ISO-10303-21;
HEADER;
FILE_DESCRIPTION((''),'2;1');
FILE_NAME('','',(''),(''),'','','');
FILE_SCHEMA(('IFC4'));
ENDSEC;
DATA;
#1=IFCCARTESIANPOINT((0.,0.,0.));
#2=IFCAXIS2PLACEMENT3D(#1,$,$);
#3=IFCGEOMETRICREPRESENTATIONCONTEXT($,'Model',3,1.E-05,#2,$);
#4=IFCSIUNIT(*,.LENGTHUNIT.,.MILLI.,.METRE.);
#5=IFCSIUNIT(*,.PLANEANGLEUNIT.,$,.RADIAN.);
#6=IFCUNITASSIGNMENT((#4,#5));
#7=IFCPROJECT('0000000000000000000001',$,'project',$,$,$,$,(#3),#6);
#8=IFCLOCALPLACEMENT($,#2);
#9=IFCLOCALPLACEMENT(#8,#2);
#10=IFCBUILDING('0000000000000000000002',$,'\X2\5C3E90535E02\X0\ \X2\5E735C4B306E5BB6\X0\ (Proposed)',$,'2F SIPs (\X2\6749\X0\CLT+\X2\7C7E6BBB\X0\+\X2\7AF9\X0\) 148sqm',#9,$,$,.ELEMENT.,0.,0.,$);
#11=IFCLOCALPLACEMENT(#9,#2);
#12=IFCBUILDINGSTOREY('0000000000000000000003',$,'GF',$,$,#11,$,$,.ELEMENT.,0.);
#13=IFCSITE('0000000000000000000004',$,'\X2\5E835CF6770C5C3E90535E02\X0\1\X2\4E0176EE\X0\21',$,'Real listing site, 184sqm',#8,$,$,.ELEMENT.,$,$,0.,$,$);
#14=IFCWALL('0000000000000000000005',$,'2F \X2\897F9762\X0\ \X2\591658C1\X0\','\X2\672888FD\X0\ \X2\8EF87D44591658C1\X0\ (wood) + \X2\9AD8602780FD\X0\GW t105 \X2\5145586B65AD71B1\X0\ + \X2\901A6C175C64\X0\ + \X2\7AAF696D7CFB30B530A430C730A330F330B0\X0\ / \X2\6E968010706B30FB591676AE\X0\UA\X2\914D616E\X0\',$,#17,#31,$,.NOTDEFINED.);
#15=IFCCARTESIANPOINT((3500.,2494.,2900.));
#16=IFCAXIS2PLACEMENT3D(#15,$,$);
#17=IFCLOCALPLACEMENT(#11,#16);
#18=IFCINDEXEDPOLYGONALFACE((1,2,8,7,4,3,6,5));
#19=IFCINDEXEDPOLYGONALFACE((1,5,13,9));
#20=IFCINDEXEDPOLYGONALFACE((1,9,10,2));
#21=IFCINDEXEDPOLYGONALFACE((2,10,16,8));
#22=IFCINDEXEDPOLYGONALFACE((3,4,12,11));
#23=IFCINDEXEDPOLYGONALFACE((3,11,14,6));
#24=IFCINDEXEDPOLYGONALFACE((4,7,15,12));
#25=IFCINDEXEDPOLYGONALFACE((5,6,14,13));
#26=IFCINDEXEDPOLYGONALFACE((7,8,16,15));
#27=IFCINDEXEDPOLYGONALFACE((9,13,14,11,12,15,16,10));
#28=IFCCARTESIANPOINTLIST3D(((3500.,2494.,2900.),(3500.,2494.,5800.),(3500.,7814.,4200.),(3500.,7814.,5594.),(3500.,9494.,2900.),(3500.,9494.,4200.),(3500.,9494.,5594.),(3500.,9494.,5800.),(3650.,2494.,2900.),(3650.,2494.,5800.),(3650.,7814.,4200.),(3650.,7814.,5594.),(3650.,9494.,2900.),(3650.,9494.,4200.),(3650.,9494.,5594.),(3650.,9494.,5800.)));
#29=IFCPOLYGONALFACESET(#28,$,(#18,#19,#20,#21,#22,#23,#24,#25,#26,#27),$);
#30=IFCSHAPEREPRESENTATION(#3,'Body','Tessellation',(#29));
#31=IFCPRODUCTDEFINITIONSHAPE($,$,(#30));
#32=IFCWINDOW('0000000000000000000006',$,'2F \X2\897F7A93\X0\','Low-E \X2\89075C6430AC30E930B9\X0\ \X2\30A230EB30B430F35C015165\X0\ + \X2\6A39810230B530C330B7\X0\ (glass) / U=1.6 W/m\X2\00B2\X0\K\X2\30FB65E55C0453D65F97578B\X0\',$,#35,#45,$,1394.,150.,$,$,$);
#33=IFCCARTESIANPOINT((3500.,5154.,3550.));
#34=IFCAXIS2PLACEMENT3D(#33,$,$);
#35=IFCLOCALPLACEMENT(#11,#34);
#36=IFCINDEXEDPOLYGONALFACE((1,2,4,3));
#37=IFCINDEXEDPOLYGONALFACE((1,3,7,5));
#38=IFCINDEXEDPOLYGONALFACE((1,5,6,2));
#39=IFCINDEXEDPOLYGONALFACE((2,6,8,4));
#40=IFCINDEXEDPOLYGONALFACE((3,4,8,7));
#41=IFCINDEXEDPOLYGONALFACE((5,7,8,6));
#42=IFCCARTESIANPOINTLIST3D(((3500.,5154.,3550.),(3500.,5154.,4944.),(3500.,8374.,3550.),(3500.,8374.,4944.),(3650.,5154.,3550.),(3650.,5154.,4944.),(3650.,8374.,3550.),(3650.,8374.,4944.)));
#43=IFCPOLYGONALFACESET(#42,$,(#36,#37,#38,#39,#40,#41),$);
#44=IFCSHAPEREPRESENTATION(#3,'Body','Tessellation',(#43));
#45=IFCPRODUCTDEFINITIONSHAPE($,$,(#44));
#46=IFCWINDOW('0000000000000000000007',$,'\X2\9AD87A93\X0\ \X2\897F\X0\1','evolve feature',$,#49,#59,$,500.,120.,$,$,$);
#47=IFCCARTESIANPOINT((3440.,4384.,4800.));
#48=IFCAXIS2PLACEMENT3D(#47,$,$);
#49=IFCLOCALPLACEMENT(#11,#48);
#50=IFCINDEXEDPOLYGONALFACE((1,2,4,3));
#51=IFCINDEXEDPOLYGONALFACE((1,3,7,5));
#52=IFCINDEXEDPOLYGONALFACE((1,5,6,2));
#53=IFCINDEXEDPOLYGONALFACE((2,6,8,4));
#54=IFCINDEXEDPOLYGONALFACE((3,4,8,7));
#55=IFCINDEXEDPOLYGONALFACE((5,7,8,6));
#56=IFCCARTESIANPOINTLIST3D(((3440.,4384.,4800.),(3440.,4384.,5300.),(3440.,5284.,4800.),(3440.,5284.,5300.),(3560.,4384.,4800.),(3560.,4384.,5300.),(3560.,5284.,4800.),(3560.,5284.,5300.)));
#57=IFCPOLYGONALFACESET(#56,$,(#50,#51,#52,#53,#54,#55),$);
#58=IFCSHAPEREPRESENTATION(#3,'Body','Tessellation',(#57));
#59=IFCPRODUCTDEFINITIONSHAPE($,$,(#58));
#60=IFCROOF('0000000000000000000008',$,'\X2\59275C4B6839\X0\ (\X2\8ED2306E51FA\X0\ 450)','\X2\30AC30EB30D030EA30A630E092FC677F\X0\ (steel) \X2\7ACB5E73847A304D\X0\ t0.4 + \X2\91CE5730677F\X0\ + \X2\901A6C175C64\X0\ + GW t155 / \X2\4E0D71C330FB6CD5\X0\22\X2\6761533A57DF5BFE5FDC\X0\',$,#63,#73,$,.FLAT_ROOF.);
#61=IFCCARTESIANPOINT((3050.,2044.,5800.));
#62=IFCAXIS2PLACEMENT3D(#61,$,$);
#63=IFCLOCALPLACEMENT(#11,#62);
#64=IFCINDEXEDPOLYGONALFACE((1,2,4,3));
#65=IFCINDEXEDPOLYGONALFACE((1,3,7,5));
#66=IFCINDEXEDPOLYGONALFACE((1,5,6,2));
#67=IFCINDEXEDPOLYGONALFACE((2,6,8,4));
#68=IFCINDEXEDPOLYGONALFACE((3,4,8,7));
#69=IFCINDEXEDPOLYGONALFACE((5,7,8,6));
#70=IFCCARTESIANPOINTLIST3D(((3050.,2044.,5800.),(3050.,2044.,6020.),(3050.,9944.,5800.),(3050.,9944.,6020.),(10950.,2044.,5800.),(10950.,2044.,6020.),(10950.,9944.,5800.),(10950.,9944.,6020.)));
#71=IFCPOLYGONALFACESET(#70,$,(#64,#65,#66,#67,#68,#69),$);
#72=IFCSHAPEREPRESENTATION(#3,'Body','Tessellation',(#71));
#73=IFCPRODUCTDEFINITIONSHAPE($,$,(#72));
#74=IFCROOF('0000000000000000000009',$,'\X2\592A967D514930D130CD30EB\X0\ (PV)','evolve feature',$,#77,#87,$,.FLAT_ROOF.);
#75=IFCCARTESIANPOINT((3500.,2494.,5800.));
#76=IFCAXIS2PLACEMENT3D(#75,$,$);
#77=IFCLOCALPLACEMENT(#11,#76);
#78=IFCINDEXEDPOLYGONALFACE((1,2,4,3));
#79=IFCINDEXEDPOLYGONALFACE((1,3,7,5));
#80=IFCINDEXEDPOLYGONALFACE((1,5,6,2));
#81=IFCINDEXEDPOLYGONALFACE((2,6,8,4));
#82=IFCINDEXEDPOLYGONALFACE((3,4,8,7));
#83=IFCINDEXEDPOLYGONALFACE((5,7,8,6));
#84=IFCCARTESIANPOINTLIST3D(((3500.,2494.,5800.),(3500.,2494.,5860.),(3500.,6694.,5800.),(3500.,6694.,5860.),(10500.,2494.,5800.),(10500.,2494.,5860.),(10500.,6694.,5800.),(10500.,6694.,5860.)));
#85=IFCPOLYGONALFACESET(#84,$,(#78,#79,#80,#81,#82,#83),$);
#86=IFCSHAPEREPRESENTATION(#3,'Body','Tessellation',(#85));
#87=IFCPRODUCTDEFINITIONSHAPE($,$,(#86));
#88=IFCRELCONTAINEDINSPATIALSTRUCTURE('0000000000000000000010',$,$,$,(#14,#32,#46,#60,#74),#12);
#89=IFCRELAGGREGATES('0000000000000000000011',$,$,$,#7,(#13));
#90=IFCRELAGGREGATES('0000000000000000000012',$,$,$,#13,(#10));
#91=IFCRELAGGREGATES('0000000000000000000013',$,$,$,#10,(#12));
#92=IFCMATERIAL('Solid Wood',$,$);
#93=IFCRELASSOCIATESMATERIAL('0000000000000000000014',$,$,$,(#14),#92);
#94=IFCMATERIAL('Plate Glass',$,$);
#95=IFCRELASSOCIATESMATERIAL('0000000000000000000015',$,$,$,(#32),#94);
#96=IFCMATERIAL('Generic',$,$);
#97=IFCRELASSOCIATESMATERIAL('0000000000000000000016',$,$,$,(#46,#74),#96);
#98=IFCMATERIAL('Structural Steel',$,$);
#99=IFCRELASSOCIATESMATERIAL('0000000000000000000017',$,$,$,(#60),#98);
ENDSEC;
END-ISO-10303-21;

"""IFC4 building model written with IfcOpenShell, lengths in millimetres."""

from ifc_helpers import new_model, si_unit, frame, frame_2d, origin, place, context, project, spatial, rectangle, extrude, material, element, fill, save


model = new_model("IFC4")

# Units and contexts
model_context = context("Model", 3, precision=1e-05, world=origin())
ifc_project = project(units=[si_unit("LENGTHUNIT", "METRE", prefix="MILLI"), si_unit("PLANEANGLEUNIT", "RADIAN")], contexts=[model_context])

# Site, building, storey
site_placement = place(None, origin())
site = spatial("IfcSite", under=ifc_project, at=site_placement, Name="広島県尾道市1丁目21", ObjectType="Real listing site, 184sqm", CompositionType="ELEMENT", RefElevation=0.0)
building_placement = place(site_placement, origin())
building = spatial("IfcBuilding", under=site, at=building_placement, Name="尾道市 平屋の家 (Proposed)", ObjectType="2F SIPs (杉CLT+籾殻+竹) 148sqm", CompositionType="ELEMENT", ElevationOfRefHeight=0.0, ElevationOfTerrain=0.0)
storey_placement = place(building_placement, origin())
storey = spatial("IfcBuildingStorey", under=building, at=storey_placement, Name="GF", CompositionType="ELEMENT", Elevation=0.0)

# Shared definitions
ifc_material_1 = material(Name="Solid Wood")
ifc_material_2 = material(Name="Generic")

# Shared definitions
ifc_material_3 = material(Name="Plate Glass")

# Wall, openings, windows
wall_1_placement = place(storey_placement, frame((3500.0, 2494.0, 2900.0)))
wall_1 = element("IfcWall", 1, at=wall_1_placement, inside=storey, material=ifc_material_1, Name="2F 西面 外壁", Description="木製 軸組外壁 (wood) + 高性能GW t105 充填断熱 + 通気層 + 窯業系サイディング / 準耐火・外皮UA配慮", PredefinedType="NOTDEFINED", context=model_context, shape_type="SweptSolid", body=[
    extrude(rectangle(XDim=150.0, YDim=7000.0, at=frame_2d((75.0, 3500.0))), frame((3500.0, 2494.0, 2900.0)), (0.0, 0.0, 1.0), 2900.0),
])
opening_1_placement = place(storey_placement, frame((3500.0, 5154.0, 3550.0)))
opening_1 = element("IfcOpeningElement", 2, at=opening_1_placement, cuts=wall_1, PredefinedType="NOTDEFINED", context=model_context, shape_type="SweptSolid", body=[
    extrude(rectangle(XDim=150.0, YDim=3220.0, at=frame_2d((75.0, 1610.0))), frame((3500.0, 5154.0, 3550.0)), (0.0, 0.0, 1.0), 1394.0),
])
opening_2_placement = place(storey_placement, frame((3440.0, 4384.0, 4800.0)))
opening_2 = element("IfcOpeningElement", 3, at=opening_2_placement, cuts=wall_1, PredefinedType="NOTDEFINED", context=model_context, shape_type="SweptSolid", body=[
    extrude(rectangle(XDim=120.0, YDim=900.0, at=frame_2d((60.0, 450.0))), frame((3440.0, 4384.0, 4800.0)), (0.0, 0.0, 1.0), 500.0),
])
window_1_placement = place(storey_placement, frame((3500.0, 5154.0, 3550.0)))
window_1 = element("IfcWindow", 4, at=window_1_placement, inside=storey, material=ifc_material_3, Name="2F 西窓", Description="Low-E 複層ガラス アルゴン封入 + 樹脂サッシ (glass) / U=1.6 W/m²K・日射取得型", OverallHeight=1394.0, OverallWidth=150.0, context=model_context, shape_type="SweptSolid", body=[
    extrude(rectangle(XDim=150.0, YDim=3220.0, at=frame_2d((75.0, 1610.0))), frame((3500.0, 5154.0, 3550.0)), (0.0, 0.0, 1.0), 1394.0),
])
fill(opening_1, window_1)
window_2_placement = place(storey_placement, frame((3440.0, 4384.0, 4800.0)))
window_2 = element("IfcWindow", 5, at=window_2_placement, inside=storey, material=ifc_material_2, Name="高窓 西1", Description="evolve feature", OverallHeight=500.0, OverallWidth=120.0, context=model_context, shape_type="SweptSolid", body=[
    extrude(rectangle(XDim=120.0, YDim=900.0, at=frame_2d((60.0, 450.0))), frame((3440.0, 4384.0, 4800.0)), (0.0, 0.0, 1.0), 500.0),
])
fill(opening_2, window_2)

# Roofs
ifc_material_4 = material(Name="Structural Steel")
roof_1_placement = place(storey_placement, frame((3050.0, 2044.0, 5800.0)))
element("IfcRoof", 6, at=roof_1_placement, inside=storey, material=ifc_material_4, Name="大屋根 (軒の出 450)", Description="ガルバリウム鋼板 (steel) 立平葺き t0.4 + 野地板 + 通気層 + GW t155 / 不燃・法22条区域対応", PredefinedType="FLAT_ROOF", context=model_context, shape_type="SweptSolid", body=[
    extrude(rectangle(XDim=7900.0, YDim=7900.0, at=frame_2d((3950.0, 3950.0))), frame((3050.0, 2044.0, 5800.0)), (0.0, 0.0, 1.0), 220.0),
])
roof_2_placement = place(storey_placement, frame((3500.0, 2494.0, 5800.0)))
element("IfcRoof", 7, at=roof_2_placement, inside=storey, material=ifc_material_2, Name="太陽光パネル (PV)", Description="evolve feature", PredefinedType="FLAT_ROOF", context=model_context, shape_type="SweptSolid", body=[
    extrude(rectangle(XDim=7000.0, YDim=4200.0, at=frame_2d((3500.0, 2100.0))), frame((3500.0, 2494.0, 5800.0)), (0.0, 0.0, 1.0), 60.0),
])

save(model, "model.ifc")
